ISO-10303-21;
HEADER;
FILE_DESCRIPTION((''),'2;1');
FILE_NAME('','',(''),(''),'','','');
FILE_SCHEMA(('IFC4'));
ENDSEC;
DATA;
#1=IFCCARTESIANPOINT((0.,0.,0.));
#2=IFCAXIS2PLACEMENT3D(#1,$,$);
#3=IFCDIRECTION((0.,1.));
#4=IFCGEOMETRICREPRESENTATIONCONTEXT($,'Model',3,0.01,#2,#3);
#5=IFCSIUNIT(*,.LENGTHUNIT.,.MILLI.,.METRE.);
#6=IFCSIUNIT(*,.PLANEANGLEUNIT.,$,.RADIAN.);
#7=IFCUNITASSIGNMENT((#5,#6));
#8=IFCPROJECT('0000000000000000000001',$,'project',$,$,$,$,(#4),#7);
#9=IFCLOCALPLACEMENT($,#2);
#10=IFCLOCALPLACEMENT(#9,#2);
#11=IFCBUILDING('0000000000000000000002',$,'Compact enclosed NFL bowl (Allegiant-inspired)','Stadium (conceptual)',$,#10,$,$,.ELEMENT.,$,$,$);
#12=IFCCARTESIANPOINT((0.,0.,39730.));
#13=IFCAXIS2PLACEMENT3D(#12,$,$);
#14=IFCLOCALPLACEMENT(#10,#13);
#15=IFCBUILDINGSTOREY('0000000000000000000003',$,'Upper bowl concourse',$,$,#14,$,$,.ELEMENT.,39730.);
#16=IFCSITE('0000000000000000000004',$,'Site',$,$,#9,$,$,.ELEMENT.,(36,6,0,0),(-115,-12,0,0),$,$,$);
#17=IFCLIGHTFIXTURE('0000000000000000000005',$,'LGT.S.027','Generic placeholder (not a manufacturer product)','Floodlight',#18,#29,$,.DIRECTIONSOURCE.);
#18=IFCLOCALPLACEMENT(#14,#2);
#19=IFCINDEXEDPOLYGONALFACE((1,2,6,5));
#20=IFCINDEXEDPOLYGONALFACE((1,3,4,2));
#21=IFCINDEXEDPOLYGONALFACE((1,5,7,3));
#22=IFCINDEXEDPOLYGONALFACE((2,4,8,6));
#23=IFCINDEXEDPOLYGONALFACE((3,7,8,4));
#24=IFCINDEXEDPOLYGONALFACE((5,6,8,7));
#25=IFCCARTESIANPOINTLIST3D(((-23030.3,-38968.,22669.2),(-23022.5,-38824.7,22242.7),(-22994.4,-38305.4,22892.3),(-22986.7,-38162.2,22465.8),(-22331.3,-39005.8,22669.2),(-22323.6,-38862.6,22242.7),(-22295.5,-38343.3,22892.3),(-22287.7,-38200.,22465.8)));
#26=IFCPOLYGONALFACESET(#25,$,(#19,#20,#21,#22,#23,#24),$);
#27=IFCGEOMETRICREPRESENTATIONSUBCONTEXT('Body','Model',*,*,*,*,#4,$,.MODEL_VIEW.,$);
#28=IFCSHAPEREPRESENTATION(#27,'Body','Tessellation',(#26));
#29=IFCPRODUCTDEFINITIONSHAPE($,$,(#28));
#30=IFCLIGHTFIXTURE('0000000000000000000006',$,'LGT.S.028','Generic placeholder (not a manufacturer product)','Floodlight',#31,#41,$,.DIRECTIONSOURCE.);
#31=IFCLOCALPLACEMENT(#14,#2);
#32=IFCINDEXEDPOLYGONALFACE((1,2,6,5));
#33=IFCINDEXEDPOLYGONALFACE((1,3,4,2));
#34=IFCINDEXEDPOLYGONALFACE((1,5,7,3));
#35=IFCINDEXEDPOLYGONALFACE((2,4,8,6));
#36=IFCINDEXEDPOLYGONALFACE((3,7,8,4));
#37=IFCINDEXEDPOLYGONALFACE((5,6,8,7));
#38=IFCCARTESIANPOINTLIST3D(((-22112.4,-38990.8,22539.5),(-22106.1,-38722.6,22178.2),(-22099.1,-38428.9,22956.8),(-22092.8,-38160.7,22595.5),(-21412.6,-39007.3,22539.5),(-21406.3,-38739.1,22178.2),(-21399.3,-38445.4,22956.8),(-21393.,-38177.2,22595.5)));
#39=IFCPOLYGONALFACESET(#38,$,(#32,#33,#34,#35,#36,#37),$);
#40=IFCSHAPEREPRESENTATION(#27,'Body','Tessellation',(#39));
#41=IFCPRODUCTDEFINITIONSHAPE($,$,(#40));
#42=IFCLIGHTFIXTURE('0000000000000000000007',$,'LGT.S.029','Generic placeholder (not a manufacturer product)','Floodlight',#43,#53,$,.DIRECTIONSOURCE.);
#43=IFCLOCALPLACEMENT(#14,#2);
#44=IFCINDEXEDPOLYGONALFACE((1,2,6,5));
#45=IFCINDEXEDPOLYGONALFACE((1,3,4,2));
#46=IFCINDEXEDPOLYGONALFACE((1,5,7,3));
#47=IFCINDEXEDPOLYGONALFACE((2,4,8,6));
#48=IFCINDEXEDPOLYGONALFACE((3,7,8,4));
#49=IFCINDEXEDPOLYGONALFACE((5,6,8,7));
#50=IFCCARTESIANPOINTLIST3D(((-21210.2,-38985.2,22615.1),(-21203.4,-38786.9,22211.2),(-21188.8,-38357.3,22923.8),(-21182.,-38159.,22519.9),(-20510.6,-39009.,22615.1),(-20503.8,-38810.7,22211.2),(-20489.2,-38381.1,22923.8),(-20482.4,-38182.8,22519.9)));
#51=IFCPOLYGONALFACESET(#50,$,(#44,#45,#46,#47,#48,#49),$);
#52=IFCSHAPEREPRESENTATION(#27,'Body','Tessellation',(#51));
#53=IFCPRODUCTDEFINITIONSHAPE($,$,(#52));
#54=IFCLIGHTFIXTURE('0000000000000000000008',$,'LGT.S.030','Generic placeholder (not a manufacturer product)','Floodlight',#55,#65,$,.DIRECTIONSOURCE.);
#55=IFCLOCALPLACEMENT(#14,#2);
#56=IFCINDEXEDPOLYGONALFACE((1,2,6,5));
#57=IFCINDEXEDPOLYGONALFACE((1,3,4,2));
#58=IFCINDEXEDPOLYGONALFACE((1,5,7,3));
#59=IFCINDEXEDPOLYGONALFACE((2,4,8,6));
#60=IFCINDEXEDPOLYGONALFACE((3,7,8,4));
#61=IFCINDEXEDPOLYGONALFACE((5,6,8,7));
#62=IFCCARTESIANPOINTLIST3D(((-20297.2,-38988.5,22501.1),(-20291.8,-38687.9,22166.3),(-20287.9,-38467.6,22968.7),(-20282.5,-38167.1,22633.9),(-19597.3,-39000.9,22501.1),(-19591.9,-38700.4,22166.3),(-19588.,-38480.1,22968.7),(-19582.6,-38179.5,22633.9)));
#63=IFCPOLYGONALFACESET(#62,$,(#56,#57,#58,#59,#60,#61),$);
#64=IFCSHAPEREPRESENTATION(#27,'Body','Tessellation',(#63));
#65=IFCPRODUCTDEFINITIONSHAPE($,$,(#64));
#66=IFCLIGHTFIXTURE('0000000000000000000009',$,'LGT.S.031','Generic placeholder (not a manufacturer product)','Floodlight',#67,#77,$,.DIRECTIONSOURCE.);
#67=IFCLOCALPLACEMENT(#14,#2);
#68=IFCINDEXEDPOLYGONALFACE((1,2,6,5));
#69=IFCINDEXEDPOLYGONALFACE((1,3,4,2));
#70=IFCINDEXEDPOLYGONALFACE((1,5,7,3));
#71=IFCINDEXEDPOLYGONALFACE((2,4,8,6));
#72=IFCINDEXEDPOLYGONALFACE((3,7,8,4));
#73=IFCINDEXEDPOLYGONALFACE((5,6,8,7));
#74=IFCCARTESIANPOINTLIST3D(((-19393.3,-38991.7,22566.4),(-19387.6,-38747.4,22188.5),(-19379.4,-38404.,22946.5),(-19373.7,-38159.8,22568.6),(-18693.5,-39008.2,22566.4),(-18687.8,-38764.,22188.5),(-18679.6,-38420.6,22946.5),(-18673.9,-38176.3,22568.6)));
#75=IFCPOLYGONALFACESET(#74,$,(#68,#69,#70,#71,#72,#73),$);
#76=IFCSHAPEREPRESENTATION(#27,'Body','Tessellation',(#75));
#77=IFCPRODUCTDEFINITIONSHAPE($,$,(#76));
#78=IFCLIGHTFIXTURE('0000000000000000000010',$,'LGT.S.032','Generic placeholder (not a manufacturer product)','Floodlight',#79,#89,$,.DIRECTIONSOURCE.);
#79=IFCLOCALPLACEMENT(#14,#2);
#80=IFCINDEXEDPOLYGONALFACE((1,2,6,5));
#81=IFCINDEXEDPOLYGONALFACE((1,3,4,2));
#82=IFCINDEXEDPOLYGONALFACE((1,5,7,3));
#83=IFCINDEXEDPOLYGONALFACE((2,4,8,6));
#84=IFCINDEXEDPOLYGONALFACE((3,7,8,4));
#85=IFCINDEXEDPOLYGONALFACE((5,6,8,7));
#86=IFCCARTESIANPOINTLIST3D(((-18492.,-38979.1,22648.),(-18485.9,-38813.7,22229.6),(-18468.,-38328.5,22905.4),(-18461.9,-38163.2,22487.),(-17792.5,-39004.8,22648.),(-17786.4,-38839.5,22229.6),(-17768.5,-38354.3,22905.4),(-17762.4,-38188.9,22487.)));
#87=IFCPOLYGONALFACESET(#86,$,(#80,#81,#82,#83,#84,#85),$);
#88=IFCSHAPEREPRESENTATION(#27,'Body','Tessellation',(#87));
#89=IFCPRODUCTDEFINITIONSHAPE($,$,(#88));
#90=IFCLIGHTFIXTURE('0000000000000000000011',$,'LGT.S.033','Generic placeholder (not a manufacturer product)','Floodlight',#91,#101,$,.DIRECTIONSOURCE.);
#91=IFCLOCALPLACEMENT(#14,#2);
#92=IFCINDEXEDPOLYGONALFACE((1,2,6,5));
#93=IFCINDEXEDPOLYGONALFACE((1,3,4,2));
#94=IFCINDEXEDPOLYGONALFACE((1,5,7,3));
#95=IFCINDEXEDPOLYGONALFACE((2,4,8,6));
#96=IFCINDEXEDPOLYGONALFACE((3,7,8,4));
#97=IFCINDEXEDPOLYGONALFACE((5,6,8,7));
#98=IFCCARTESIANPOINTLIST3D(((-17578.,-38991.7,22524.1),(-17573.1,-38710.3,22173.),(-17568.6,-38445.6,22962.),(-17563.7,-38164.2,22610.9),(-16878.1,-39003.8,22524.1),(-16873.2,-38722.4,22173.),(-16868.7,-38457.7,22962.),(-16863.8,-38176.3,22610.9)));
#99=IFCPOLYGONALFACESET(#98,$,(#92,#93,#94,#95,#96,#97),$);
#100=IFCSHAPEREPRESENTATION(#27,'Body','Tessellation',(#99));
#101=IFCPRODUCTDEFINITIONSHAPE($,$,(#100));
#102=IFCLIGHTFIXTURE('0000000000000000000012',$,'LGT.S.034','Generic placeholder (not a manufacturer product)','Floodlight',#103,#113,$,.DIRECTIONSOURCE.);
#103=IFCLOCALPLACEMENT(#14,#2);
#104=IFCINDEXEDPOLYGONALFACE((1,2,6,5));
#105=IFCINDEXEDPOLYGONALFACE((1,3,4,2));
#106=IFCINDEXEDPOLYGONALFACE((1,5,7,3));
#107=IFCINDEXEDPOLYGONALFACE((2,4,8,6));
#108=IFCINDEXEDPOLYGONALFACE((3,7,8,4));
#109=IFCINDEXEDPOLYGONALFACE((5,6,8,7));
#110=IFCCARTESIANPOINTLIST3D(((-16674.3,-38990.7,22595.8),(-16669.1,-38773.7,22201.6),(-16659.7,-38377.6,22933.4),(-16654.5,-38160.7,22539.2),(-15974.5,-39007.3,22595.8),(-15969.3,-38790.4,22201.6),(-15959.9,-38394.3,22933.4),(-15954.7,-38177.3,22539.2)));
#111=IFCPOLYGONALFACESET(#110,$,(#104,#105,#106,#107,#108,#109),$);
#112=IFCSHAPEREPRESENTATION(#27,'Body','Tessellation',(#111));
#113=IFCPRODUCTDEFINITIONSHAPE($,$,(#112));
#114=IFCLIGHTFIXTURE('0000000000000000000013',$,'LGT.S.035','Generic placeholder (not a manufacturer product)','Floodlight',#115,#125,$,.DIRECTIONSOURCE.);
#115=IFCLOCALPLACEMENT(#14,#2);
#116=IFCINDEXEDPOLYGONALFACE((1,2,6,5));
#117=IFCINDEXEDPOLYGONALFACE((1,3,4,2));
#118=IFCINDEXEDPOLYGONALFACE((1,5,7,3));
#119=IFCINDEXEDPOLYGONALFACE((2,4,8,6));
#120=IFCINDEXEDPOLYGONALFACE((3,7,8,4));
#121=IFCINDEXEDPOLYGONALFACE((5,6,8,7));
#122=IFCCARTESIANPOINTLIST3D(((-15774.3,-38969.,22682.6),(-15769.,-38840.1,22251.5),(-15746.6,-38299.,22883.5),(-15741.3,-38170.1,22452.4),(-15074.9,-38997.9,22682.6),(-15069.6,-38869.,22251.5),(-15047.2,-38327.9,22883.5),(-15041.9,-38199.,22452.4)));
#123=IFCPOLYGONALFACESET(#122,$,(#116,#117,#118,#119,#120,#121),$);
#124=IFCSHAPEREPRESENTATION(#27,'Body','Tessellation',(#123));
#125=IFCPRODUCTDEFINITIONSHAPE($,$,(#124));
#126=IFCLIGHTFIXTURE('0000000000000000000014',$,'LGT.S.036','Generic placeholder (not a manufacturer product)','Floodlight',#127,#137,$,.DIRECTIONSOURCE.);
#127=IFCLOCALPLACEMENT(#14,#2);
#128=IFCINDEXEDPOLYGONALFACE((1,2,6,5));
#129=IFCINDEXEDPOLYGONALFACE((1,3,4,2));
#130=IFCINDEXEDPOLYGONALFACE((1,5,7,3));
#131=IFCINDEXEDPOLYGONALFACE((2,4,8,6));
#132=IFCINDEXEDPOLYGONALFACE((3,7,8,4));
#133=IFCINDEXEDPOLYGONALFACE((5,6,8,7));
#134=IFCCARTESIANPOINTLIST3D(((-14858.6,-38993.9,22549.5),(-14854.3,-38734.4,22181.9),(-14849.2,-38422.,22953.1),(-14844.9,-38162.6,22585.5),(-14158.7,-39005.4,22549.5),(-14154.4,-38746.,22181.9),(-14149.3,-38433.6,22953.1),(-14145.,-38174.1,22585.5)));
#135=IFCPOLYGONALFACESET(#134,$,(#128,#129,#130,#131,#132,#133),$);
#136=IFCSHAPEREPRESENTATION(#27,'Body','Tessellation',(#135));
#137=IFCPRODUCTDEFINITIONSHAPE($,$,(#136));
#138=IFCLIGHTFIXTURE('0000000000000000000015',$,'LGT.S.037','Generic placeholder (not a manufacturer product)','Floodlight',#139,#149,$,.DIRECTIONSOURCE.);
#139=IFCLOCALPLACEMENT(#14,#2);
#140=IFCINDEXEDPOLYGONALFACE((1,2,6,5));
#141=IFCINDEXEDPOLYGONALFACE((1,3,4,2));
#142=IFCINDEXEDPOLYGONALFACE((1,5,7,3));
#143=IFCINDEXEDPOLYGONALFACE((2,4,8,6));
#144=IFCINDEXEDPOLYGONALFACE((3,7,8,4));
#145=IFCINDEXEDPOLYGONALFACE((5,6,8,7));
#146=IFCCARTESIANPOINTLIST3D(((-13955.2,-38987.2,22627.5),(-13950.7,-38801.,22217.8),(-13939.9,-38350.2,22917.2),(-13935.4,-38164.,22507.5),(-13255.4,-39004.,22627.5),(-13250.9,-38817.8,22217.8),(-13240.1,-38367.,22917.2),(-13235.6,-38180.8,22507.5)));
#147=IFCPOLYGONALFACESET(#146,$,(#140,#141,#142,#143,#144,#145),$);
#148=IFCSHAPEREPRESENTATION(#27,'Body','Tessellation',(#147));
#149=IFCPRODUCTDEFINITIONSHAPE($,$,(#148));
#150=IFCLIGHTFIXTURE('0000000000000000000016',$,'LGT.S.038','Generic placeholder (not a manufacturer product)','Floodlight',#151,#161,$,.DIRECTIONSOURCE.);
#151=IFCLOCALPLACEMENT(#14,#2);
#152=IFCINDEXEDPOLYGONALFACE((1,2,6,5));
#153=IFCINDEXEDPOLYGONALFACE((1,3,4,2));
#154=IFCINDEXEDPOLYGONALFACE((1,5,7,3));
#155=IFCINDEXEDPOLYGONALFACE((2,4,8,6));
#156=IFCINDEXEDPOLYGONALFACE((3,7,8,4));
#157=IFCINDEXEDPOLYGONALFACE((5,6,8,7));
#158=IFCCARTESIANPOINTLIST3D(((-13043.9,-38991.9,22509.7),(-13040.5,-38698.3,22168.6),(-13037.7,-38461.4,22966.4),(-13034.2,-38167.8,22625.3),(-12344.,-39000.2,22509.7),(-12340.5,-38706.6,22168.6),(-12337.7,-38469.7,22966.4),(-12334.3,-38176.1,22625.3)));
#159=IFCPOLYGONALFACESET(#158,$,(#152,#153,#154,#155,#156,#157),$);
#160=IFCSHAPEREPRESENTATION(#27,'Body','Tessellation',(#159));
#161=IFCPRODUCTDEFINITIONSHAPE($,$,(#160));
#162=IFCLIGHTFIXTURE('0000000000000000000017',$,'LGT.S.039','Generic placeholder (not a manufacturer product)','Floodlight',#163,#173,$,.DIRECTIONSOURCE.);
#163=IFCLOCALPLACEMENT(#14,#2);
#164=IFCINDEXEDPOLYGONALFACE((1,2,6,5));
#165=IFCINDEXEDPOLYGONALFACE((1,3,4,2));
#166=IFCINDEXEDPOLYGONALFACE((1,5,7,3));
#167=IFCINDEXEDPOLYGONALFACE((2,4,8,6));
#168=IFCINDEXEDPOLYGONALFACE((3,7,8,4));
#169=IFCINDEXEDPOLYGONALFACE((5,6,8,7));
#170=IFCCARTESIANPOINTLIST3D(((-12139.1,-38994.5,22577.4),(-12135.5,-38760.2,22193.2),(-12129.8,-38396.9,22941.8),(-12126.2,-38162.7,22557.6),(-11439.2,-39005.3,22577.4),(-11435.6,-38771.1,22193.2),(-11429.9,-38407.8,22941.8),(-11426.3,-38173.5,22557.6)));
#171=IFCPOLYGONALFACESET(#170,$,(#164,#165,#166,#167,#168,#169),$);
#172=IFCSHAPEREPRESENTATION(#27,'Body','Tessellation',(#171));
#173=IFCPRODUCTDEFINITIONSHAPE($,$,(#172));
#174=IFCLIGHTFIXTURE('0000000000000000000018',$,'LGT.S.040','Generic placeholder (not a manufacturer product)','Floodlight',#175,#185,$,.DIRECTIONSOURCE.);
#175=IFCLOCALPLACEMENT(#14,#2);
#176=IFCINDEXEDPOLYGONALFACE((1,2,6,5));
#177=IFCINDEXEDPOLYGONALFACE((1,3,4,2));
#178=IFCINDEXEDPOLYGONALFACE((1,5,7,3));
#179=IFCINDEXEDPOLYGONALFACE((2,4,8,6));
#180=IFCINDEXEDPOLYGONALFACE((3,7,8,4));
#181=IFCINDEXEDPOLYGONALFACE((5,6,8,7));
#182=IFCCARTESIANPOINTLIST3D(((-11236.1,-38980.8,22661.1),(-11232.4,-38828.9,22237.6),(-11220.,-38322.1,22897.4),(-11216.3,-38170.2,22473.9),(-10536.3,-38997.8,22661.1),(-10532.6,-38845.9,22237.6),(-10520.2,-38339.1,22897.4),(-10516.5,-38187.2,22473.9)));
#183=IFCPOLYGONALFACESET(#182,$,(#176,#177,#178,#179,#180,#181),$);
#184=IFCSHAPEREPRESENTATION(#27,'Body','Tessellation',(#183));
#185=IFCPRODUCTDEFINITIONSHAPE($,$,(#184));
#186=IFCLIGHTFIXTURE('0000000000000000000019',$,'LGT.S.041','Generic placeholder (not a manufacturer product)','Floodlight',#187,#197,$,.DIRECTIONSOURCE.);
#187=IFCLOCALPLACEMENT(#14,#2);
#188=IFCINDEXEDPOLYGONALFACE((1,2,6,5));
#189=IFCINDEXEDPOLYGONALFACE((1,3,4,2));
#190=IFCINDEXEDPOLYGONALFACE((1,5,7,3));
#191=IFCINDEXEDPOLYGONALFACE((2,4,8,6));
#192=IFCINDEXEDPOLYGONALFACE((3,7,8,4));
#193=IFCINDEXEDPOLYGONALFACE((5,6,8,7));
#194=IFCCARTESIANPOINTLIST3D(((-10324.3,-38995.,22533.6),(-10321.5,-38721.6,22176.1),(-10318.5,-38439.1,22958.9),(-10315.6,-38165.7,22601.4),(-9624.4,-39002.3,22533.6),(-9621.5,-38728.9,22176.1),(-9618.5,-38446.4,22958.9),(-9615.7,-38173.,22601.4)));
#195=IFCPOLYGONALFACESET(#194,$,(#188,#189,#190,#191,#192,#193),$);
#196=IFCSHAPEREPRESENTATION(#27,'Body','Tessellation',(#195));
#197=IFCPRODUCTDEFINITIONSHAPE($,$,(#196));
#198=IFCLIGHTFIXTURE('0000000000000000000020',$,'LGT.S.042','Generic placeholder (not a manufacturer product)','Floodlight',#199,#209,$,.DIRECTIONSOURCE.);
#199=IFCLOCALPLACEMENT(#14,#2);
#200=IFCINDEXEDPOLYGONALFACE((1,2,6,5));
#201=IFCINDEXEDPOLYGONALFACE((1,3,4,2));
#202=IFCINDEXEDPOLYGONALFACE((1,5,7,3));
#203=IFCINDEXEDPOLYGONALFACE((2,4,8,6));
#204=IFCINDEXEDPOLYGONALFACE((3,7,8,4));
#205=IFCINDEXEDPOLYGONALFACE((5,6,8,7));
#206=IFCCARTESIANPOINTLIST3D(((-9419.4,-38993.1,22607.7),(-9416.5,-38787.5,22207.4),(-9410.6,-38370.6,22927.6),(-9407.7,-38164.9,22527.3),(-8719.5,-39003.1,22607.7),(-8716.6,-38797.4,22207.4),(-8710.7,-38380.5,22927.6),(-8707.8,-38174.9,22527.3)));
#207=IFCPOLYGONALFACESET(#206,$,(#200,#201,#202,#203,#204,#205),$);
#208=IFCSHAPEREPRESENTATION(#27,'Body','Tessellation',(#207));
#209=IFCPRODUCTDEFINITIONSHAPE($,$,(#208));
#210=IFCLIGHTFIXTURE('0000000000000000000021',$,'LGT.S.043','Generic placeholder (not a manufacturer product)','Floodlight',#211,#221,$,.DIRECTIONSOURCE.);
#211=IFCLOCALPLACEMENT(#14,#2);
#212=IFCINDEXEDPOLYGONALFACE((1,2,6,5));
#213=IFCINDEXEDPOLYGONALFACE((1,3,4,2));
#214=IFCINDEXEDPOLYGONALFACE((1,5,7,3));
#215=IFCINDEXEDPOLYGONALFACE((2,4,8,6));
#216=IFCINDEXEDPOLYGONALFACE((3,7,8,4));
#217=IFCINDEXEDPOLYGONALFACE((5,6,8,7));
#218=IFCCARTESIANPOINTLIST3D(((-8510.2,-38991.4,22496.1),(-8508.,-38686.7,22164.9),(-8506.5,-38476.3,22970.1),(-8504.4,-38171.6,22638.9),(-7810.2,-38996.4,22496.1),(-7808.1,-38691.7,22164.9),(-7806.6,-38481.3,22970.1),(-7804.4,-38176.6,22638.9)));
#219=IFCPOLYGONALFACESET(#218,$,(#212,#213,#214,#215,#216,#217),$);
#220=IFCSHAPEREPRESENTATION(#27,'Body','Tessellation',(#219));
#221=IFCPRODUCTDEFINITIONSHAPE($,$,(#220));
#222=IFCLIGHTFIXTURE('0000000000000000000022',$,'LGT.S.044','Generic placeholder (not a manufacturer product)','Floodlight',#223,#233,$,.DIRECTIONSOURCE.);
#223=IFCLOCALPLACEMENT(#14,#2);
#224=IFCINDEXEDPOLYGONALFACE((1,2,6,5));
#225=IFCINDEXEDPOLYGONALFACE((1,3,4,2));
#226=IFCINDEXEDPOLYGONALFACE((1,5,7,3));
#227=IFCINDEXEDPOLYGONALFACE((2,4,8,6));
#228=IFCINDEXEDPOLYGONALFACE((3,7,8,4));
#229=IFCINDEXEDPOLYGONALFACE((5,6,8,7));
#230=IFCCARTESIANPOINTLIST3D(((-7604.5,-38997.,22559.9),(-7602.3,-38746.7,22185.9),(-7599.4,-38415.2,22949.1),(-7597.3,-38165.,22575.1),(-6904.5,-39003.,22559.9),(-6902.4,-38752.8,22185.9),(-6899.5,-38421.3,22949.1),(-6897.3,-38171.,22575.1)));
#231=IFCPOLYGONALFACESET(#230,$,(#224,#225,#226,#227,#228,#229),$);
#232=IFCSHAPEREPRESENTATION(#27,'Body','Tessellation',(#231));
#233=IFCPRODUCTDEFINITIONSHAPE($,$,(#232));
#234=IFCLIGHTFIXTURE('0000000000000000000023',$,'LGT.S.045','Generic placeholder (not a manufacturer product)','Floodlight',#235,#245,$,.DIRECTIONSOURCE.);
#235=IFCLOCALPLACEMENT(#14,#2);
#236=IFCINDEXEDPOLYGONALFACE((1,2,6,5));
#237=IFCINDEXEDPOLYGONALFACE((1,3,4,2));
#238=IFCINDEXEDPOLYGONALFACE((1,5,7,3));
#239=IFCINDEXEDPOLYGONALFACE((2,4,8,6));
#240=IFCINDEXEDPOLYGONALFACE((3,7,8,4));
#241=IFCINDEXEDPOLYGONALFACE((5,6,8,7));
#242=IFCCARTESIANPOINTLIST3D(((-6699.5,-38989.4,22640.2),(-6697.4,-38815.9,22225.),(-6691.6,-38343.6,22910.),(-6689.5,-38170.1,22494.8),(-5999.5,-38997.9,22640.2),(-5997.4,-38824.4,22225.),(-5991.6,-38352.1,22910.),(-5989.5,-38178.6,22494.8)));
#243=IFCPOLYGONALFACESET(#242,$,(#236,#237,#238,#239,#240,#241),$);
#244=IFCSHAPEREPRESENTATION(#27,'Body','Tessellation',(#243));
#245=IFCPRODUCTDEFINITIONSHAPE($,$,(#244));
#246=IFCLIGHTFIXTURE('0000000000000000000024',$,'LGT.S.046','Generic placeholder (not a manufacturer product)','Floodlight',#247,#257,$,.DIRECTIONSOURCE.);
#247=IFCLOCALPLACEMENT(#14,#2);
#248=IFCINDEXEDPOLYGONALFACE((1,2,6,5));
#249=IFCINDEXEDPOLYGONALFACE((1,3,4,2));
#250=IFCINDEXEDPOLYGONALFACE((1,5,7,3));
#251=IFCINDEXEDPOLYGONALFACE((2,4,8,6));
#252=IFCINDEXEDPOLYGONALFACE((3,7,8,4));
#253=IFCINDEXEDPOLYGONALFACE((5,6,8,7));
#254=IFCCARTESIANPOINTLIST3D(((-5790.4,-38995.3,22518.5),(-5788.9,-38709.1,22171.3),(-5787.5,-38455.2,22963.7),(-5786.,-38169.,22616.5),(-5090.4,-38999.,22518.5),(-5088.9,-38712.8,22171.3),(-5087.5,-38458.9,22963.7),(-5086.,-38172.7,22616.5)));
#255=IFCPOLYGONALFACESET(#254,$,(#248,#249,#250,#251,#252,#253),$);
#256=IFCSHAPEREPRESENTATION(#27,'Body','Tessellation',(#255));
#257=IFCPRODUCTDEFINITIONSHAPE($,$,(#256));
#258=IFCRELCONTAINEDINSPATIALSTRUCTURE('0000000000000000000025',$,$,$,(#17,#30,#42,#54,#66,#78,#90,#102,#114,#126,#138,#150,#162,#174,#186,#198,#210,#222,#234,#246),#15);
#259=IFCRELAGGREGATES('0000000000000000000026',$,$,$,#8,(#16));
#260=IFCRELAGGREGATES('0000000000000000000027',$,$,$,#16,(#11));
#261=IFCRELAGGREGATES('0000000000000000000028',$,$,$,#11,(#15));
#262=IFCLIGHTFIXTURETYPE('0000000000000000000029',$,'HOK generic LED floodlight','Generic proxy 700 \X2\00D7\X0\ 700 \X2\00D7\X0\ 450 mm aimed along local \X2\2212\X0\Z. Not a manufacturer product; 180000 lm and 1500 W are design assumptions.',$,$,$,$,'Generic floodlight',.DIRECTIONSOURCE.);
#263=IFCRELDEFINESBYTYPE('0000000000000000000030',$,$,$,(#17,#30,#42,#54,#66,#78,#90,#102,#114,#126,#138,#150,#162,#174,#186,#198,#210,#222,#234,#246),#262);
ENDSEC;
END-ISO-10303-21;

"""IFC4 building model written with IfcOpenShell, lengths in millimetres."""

from ifc_helpers import new_model, si_unit, direction, frame, origin, place, context, subcontext, project, spatial, rectangle, extrude, source, transform, mapped, type_object, type_shapes, element, save


model = new_model("IFC4")

# Units and contexts
model_context = context("Model", 3, precision=0.01, world=origin(), true_north=direction((0.0, 1.0)))
body_context = subcontext(model_context, "Body", "Model", "MODEL_VIEW")
ifc_project = project(units=[si_unit("LENGTHUNIT", "METRE", prefix="MILLI"), si_unit("PLANEANGLEUNIT", "RADIAN")], contexts=[model_context])

# Site, building, storey
site_placement = place(None, origin())
site = spatial("IfcSite", under=ifc_project, at=site_placement, Name="Site", CompositionType="ELEMENT", RefLatitude=(36, 6, 0, 0), RefLongitude=(-115, -12, 0, 0))
building_placement = place(site_placement, origin())
building = spatial("IfcBuilding", under=site, at=building_placement, Name="Compact enclosed NFL bowl (Allegiant-inspired)", Description="Stadium (conceptual)", CompositionType="ELEMENT")
storey_placement = place(building_placement, frame((0.0, 0.0, 39730.0)))
storey = spatial("IfcBuildingStorey", under=building, at=storey_placement, Name="Upper bowl concourse", CompositionType="ELEMENT", Elevation=39730.0)

# Light fixtures
light_fixture_type = type_object("IfcLightFixtureType", Name="HOK generic LED floodlight", Description="Generic proxy 700 × 700 × 450 mm aimed along local −Z. Not a manufacturer product; 180000 lm and 1500 W are design assumptions.", ElementType="Generic floodlight", PredefinedType="DIRECTIONSOURCE")
shared_shape = source(origin(), body_context, "Body", "SweptSolid", [
    extrude(rectangle(XDim=700.0, YDim=700.0), frame((0.0, 0.0, -225.0)), (0.0, 0.0, 1.0), 450.0),
])
type_shapes(light_fixture_type, [shared_shape])
for number, where, z_axis, x_axis, name in (
    (1, (-22659.0, -38584.0, 22567.5), (-0.017237, -0.318336, 0.947821), (0.998537, -0.054069, 0.0), "LGT.S.027"),
    (2, (-21752.7, -38584.0, 22567.5), (-0.014017, -0.595958, 0.802893), (0.999723, -0.023514, 0.0), "LGT.S.028"),
    (3, (-20846.3, -38584.0, 22567.5), (-0.015016, -0.440756, 0.897501), (0.99942, -0.03405, 0.0), "LGT.S.029"),
    (4, (-19939.9, -38584.0, 22567.5), (-0.01191, -0.667887, 0.744168), (0.999841, -0.017829, 0.0), "LGT.S.030"),
    (5, (-19033.6, -38584.0, 22567.5), (-0.012829, -0.542772, 0.839782), (0.999721, -0.023629, 0.0), "LGT.S.031"),
    (6, (-18127.2, -38584.0, 22567.5), (-0.01353, -0.367468, 0.929938), (0.999323, -0.036793, 0.0), "LGT.S.032"),
    (7, (-17220.9, -38584.0, 22567.5), (-0.010784, -0.625399, 0.780231), (0.999851, -0.017241, 0.0), "LGT.S.033"),
    (8, (-16314.5, -38584.0, 22567.5), (-0.011471, -0.482146, 0.876016), (0.999717, -0.023784, 0.0), "LGT.S.034"),
    (9, (-15408.1, -38584.0, 22567.5), (-0.011847, -0.286638, 0.957966), (0.999147, -0.041295, 0.0), "LGT.S.035"),
    (10, (-14501.8, -38584.0, 22567.5), (-0.00951, -0.576513, 0.817033), (0.999864, -0.016493, 0.0), "LGT.S.036"),
    (11, (-13595.4, -38584.0, 22567.5), (-0.009934, -0.413708, 0.910355), (0.999712, -0.024004, 0.0), "LGT.S.037"),
    (12, (-12689.1, -38584.0, 22567.5), (-0.007718, -0.65239, 0.757844), (0.99993, -0.01183, 0.0), "LGT.S.038"),
    (13, (-11782.7, -38584.0, 22567.5), (-0.008074, -0.520542, 0.853798), (0.99988, -0.015509, 0.0), "LGT.S.039"),
    (14, (-10876.3, -38584.0, 22567.5), (-0.008217, -0.337465, 0.941302), (0.999704, -0.024342, 0.0), "LGT.S.040"),
    (15, (-9970.0, -38584.0, 22567.5), (-0.006356, -0.607541, 0.794263), (0.999945, -0.010461, 0.0), "LGT.S.041"),
    (16, (-9063.6, -38584.0, 22567.5), (-0.00647, -0.456955, 0.889466), (0.9999, -0.014158, 0.0), "LGT.S.042"),
    (17, (-8157.3, -38584.0, 22567.5), (-0.004818, -0.677106, 0.73587), (0.999975, -0.007115, 0.0), "LGT.S.043"),
    (18, (-7250.9, -38584.0, 22567.5), (-0.004837, -0.55602, 0.831155), (0.999962, -0.008699, 0.0), "LGT.S.044"),
    (19, (-6344.5, -38584.0, 22567.5), (-0.004698, -0.385503, 0.922694), (0.999926, -0.012187, 0.0), "LGT.S.045"),
    (20, (-5438.2, -38584.0, 22567.5), (-0.003368, -0.636014, 0.77167), (0.999986, -0.005296, 0.0), "LGT.S.046"),
):
    element("IfcLightFixture", number, at=place(storey_placement, frame(where, z_axis=z_axis, x_axis=x_axis)), inside=storey, type_object=light_fixture_type, Name=name, Description="Generic placeholder (not a manufacturer product)", ObjectType="Floodlight", PredefinedType="DIRECTIONSOURCE", context=body_context, shape_type="MappedRepresentation", body=[
        mapped(shared_shape, transform((0.0, 0.0, 0.0))),
    ])

save(model, "model.ifc")
